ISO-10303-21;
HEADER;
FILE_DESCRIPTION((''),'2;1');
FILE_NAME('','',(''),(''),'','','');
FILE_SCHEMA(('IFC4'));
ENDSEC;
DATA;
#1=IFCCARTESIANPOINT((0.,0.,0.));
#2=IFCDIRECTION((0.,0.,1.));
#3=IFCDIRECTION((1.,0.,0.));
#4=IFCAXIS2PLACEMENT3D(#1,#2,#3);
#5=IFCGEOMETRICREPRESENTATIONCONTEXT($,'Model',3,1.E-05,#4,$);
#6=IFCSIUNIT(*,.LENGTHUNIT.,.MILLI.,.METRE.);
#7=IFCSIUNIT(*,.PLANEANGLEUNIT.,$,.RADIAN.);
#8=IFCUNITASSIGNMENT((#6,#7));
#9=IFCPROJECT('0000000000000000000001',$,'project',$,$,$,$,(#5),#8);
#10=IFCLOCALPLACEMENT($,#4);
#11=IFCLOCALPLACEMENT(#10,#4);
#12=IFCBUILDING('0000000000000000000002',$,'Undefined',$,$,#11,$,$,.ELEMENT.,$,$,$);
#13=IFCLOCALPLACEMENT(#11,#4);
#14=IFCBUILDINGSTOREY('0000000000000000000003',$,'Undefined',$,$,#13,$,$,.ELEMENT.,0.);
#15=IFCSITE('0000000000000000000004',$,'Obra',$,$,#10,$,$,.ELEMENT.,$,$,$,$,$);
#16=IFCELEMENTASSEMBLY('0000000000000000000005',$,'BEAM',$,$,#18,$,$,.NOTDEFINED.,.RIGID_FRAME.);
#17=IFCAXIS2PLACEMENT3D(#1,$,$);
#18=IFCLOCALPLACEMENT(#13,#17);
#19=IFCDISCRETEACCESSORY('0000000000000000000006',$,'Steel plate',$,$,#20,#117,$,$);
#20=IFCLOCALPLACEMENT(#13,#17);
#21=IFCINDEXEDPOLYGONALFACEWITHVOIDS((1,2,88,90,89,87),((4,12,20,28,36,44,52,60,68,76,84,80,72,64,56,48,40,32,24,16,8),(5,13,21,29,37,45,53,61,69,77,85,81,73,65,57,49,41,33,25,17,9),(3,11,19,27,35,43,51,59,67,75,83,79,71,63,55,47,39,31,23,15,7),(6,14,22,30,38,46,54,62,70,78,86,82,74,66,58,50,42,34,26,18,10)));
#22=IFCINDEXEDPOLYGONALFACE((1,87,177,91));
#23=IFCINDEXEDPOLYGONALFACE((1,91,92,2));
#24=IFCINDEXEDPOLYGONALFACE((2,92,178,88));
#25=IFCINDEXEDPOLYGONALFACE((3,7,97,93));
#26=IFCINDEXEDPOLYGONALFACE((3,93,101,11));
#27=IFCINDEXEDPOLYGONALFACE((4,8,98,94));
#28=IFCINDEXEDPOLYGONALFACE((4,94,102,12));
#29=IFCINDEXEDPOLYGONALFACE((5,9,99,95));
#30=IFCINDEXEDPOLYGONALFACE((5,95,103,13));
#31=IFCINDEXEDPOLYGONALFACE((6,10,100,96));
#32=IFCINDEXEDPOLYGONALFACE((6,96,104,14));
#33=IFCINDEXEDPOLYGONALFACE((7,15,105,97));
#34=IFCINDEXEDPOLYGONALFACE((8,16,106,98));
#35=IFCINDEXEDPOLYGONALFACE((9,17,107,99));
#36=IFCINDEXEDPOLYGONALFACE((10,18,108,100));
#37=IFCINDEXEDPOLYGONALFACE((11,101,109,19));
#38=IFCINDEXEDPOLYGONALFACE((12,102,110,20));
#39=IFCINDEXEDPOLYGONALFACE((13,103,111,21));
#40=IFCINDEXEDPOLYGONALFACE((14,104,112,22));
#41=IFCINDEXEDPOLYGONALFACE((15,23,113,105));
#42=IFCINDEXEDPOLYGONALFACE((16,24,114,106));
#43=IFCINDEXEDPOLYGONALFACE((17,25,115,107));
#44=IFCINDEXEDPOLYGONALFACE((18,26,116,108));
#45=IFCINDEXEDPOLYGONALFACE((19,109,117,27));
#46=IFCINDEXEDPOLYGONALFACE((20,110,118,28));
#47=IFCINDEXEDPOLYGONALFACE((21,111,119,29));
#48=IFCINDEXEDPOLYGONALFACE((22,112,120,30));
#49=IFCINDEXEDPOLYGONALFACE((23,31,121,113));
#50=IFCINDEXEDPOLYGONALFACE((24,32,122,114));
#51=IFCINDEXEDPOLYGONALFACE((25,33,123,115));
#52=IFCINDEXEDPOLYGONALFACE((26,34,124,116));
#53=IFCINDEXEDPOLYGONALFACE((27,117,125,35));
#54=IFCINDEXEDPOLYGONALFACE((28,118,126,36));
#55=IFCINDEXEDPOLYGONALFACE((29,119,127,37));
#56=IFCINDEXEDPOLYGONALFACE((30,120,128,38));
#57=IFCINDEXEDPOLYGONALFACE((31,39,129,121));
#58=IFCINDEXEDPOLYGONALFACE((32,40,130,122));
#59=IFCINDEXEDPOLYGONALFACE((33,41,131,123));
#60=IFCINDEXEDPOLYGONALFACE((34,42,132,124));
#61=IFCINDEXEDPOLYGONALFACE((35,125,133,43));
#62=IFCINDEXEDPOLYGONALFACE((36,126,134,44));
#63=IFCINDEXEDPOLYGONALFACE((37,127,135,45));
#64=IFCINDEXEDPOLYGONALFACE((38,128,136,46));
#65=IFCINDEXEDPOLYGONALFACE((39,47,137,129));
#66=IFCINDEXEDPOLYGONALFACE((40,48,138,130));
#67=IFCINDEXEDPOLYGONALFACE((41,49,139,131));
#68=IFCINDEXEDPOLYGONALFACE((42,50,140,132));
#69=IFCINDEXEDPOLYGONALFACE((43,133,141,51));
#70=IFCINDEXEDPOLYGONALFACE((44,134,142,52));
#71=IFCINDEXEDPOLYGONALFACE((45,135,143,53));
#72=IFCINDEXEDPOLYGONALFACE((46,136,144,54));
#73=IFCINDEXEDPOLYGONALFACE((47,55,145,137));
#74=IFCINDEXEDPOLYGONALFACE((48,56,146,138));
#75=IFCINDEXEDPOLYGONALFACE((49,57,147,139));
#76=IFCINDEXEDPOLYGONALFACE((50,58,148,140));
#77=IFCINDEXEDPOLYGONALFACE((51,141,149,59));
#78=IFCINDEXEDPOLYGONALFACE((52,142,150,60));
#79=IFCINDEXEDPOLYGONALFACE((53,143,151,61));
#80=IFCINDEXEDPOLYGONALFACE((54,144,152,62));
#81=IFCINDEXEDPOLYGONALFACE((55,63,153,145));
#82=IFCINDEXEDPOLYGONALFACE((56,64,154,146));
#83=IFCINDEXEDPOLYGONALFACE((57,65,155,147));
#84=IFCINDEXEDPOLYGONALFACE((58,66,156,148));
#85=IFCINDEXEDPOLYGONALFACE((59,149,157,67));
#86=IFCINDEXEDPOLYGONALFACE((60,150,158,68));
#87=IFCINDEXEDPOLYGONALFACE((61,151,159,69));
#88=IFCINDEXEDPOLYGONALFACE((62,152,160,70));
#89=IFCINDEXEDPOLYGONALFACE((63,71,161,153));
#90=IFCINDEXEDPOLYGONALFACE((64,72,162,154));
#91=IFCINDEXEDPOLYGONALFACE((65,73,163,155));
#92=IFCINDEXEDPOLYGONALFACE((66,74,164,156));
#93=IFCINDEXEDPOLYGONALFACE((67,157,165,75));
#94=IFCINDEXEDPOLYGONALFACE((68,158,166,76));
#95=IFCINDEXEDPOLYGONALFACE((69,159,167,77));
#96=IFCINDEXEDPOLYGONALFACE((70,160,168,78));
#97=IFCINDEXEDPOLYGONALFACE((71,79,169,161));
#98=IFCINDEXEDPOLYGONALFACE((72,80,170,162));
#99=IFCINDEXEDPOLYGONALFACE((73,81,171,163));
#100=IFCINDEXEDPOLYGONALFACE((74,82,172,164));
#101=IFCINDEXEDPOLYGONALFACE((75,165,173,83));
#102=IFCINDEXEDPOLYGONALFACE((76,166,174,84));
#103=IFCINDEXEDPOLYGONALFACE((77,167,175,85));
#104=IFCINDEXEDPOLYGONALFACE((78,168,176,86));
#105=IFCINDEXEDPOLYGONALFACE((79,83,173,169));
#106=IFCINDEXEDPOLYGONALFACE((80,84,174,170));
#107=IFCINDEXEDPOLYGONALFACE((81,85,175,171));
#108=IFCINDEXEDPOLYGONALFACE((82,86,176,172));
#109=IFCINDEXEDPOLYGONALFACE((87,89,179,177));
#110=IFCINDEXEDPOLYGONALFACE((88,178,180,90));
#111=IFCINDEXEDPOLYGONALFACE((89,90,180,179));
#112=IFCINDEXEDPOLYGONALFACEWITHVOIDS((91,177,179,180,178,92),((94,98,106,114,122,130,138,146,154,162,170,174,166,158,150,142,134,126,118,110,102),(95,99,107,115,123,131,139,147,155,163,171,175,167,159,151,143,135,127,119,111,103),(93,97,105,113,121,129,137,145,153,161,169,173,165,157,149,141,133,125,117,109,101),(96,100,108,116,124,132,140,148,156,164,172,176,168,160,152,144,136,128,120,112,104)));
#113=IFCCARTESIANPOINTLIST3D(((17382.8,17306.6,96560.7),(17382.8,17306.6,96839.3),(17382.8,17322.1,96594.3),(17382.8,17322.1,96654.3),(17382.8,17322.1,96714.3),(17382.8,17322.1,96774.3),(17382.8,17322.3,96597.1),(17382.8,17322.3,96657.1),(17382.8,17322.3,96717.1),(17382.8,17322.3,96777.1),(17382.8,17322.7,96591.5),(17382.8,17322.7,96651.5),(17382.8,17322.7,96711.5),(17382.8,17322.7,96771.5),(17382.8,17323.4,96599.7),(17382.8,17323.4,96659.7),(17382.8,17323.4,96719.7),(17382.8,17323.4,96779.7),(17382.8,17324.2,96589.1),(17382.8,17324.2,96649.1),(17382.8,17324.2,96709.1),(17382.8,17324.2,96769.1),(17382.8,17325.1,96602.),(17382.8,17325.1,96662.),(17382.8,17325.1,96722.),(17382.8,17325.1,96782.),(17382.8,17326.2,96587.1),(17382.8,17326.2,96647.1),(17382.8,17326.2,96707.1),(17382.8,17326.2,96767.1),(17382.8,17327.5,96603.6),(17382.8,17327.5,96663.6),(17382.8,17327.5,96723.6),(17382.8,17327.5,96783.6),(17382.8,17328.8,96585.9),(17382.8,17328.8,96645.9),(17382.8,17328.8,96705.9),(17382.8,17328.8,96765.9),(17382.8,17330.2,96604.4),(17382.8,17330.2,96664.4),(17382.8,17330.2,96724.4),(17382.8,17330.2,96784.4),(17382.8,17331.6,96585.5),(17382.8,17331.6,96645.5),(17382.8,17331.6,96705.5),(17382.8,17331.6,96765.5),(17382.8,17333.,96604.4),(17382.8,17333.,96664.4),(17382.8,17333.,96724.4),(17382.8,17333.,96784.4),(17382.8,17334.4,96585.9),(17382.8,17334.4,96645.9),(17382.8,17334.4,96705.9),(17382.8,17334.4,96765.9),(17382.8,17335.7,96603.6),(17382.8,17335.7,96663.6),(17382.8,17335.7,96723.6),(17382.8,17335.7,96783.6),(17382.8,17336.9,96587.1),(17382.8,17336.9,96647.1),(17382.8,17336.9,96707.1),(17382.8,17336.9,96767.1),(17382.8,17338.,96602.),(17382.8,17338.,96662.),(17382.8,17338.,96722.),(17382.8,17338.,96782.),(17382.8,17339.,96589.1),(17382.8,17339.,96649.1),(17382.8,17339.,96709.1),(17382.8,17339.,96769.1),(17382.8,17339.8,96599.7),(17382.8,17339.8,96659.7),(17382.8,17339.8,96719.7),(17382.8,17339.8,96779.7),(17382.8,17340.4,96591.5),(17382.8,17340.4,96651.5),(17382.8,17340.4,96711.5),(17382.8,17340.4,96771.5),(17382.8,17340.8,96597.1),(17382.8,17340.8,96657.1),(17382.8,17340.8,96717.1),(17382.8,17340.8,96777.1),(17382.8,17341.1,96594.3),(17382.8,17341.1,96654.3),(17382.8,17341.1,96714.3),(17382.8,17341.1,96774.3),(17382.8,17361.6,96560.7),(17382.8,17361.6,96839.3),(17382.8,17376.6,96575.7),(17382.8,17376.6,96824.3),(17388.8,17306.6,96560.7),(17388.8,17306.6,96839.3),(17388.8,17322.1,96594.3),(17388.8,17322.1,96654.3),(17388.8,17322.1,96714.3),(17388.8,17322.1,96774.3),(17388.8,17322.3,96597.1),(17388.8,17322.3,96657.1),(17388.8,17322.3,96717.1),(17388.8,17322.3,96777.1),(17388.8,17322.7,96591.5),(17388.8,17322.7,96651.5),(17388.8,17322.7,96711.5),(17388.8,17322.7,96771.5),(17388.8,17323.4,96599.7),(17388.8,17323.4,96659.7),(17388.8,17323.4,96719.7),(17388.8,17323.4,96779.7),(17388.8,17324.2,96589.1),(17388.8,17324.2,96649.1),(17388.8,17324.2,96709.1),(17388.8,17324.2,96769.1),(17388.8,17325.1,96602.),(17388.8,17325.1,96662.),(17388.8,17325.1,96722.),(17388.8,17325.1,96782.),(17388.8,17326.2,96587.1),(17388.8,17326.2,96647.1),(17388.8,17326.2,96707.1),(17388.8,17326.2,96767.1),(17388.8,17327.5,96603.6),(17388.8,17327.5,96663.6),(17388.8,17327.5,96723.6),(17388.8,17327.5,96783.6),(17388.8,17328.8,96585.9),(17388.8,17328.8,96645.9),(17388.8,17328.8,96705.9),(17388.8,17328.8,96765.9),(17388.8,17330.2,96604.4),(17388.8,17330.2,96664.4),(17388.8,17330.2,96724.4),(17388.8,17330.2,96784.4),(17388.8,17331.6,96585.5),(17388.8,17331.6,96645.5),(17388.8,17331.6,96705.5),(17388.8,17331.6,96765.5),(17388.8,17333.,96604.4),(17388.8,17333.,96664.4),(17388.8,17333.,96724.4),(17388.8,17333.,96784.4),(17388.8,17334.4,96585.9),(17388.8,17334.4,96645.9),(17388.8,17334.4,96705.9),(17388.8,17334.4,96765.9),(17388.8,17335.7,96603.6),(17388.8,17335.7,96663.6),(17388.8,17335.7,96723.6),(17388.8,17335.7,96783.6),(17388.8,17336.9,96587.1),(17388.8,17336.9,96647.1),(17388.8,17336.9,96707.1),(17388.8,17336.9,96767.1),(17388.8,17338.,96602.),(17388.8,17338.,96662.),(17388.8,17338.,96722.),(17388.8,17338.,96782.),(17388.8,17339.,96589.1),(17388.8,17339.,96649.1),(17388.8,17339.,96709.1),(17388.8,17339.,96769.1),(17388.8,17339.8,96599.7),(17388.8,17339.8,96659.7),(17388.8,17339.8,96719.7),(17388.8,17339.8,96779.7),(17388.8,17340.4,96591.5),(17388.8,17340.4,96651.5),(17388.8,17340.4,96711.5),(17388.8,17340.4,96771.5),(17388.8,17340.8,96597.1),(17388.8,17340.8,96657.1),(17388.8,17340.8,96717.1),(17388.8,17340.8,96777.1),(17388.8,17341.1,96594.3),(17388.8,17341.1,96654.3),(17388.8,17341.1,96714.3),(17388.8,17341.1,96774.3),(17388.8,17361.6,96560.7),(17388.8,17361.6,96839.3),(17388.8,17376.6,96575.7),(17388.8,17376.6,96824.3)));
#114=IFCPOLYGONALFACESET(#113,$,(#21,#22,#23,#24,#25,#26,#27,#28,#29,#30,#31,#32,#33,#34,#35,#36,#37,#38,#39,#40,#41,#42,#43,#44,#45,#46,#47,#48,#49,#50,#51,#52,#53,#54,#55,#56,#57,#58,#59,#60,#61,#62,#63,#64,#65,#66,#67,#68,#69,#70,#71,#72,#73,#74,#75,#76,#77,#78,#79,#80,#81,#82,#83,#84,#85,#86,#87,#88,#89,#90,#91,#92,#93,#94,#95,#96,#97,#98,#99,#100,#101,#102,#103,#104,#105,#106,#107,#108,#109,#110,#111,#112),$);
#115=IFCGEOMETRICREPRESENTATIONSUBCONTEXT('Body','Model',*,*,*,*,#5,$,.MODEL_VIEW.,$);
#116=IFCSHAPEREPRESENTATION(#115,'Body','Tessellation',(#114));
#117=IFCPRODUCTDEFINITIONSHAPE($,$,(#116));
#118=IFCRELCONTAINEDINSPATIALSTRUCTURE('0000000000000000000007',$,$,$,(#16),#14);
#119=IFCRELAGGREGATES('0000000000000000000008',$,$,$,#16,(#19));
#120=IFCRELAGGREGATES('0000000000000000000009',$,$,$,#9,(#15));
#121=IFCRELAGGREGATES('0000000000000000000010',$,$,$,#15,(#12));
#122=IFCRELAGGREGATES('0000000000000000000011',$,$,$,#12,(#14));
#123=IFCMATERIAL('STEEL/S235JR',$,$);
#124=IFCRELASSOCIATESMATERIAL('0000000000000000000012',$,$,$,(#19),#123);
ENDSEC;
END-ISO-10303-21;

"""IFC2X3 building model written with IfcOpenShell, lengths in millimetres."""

from ifc_helpers import new_model, si_unit, frame, origin_with_axes, origin_2d_with_axis, place, context, subcontext, project, spatial, polyline, circle, outline, extrude, source, transform, mapped, material, element, aggregate, save


model = new_model("IFC2X3")

# Units and contexts
model_context = context("Model", 3, precision=1e-05, world=origin_with_axes())
body_context = subcontext(model_context, "Body", "Model", "MODEL_VIEW")
ifc_project = project(units=[si_unit("LENGTHUNIT", "METRE", prefix="MILLI"), si_unit("PLANEANGLEUNIT", "RADIAN")], contexts=[model_context])

# Site, building, storey
site_placement = place(None, origin_with_axes())
site = spatial("IfcSite", under=ifc_project, at=site_placement, Name="Obra", CompositionType="ELEMENT")
building_placement = place(site_placement, origin_with_axes())
building = spatial("IfcBuilding", under=site, at=building_placement, Name="Undefined", CompositionType="ELEMENT")
storey_placement = place(building_placement, origin_with_axes())
storey = spatial("IfcBuildingStorey", under=building, at=storey_placement, Name="Undefined", CompositionType="ELEMENT", Elevation=0.0)

# Element assembly, discrete accessory, opening
assembly_1_placement = place(storey_placement, origin_with_axes())
assembly_1 = element("IfcElementAssembly", 1, at=assembly_1_placement, inside=storey, Name="BEAM", AssemblyPlace="NOTDEFINED", PredefinedType="RIGID_FRAME")
ifc_material_1 = material(Name="STEEL/S235JR")
shared_shape_1 = source(origin_with_axes(), body_context, "Body", "SweptSolid", [
    extrude(circle(Radius=9.5, at=origin_2d_with_axis()), frame((0.0, -9.8, 0.0), z_axis=(0.0, 1.0, 0.0), x_axis=(1.0, 0.0, 0.0)), (0.0, 0.0, 1.0), 6.2),
])
discrete_accessory_1_placement = place(assembly_1_placement, frame((17385.8, 17306.6, 96560.7), z_axis=(1.0, 0.0, 0.0), x_axis=(0.0, 1.0, 0.0)))
discrete_accessory_1 = element("IfcDiscreteAccessory", 2, at=discrete_accessory_1_placement, material=ifc_material_1, Name="Steel plate", context=body_context, shape_type="SweptSolid", body=[
    extrude(outline(polyline([(0.0, 0.0), (55.0, 0.0), (70.0, 15.0), (70.0, 263.6), (55.0, 278.6), (0.0, 278.6), (0.0, 0.0)])), frame((0.0, 0.0, -3.0), z_axis=(0.0, 0.0, 1.0), x_axis=(1.0, 0.0, 0.0)), (0.0, 0.0, 1.0), 6.0),
])
opening_1_placement = place(assembly_1_placement, frame((17392.6, 17366.6, 96850.0), z_axis=(0.0, -1.0, 0.0), x_axis=(0.0, 0.0, -1.0)))
element("IfcOpeningElement", 3, at=opening_1_placement, cuts=discrete_accessory_1, ObjectType="Opening", context=body_context, shape_type="MappedRepresentation", body=[
    mapped(shared_shape_1, transform((75.0, 0.0, 35.0))),
    mapped(shared_shape_1, transform((135.0, 0.0, 35.0))),
    mapped(shared_shape_1, transform((195.0, 0.0, 35.0))),
    mapped(shared_shape_1, transform((255.0, 0.0, 35.0))),
])

aggregate(assembly_1, [discrete_accessory_1])

save(model, "model.ifc")
